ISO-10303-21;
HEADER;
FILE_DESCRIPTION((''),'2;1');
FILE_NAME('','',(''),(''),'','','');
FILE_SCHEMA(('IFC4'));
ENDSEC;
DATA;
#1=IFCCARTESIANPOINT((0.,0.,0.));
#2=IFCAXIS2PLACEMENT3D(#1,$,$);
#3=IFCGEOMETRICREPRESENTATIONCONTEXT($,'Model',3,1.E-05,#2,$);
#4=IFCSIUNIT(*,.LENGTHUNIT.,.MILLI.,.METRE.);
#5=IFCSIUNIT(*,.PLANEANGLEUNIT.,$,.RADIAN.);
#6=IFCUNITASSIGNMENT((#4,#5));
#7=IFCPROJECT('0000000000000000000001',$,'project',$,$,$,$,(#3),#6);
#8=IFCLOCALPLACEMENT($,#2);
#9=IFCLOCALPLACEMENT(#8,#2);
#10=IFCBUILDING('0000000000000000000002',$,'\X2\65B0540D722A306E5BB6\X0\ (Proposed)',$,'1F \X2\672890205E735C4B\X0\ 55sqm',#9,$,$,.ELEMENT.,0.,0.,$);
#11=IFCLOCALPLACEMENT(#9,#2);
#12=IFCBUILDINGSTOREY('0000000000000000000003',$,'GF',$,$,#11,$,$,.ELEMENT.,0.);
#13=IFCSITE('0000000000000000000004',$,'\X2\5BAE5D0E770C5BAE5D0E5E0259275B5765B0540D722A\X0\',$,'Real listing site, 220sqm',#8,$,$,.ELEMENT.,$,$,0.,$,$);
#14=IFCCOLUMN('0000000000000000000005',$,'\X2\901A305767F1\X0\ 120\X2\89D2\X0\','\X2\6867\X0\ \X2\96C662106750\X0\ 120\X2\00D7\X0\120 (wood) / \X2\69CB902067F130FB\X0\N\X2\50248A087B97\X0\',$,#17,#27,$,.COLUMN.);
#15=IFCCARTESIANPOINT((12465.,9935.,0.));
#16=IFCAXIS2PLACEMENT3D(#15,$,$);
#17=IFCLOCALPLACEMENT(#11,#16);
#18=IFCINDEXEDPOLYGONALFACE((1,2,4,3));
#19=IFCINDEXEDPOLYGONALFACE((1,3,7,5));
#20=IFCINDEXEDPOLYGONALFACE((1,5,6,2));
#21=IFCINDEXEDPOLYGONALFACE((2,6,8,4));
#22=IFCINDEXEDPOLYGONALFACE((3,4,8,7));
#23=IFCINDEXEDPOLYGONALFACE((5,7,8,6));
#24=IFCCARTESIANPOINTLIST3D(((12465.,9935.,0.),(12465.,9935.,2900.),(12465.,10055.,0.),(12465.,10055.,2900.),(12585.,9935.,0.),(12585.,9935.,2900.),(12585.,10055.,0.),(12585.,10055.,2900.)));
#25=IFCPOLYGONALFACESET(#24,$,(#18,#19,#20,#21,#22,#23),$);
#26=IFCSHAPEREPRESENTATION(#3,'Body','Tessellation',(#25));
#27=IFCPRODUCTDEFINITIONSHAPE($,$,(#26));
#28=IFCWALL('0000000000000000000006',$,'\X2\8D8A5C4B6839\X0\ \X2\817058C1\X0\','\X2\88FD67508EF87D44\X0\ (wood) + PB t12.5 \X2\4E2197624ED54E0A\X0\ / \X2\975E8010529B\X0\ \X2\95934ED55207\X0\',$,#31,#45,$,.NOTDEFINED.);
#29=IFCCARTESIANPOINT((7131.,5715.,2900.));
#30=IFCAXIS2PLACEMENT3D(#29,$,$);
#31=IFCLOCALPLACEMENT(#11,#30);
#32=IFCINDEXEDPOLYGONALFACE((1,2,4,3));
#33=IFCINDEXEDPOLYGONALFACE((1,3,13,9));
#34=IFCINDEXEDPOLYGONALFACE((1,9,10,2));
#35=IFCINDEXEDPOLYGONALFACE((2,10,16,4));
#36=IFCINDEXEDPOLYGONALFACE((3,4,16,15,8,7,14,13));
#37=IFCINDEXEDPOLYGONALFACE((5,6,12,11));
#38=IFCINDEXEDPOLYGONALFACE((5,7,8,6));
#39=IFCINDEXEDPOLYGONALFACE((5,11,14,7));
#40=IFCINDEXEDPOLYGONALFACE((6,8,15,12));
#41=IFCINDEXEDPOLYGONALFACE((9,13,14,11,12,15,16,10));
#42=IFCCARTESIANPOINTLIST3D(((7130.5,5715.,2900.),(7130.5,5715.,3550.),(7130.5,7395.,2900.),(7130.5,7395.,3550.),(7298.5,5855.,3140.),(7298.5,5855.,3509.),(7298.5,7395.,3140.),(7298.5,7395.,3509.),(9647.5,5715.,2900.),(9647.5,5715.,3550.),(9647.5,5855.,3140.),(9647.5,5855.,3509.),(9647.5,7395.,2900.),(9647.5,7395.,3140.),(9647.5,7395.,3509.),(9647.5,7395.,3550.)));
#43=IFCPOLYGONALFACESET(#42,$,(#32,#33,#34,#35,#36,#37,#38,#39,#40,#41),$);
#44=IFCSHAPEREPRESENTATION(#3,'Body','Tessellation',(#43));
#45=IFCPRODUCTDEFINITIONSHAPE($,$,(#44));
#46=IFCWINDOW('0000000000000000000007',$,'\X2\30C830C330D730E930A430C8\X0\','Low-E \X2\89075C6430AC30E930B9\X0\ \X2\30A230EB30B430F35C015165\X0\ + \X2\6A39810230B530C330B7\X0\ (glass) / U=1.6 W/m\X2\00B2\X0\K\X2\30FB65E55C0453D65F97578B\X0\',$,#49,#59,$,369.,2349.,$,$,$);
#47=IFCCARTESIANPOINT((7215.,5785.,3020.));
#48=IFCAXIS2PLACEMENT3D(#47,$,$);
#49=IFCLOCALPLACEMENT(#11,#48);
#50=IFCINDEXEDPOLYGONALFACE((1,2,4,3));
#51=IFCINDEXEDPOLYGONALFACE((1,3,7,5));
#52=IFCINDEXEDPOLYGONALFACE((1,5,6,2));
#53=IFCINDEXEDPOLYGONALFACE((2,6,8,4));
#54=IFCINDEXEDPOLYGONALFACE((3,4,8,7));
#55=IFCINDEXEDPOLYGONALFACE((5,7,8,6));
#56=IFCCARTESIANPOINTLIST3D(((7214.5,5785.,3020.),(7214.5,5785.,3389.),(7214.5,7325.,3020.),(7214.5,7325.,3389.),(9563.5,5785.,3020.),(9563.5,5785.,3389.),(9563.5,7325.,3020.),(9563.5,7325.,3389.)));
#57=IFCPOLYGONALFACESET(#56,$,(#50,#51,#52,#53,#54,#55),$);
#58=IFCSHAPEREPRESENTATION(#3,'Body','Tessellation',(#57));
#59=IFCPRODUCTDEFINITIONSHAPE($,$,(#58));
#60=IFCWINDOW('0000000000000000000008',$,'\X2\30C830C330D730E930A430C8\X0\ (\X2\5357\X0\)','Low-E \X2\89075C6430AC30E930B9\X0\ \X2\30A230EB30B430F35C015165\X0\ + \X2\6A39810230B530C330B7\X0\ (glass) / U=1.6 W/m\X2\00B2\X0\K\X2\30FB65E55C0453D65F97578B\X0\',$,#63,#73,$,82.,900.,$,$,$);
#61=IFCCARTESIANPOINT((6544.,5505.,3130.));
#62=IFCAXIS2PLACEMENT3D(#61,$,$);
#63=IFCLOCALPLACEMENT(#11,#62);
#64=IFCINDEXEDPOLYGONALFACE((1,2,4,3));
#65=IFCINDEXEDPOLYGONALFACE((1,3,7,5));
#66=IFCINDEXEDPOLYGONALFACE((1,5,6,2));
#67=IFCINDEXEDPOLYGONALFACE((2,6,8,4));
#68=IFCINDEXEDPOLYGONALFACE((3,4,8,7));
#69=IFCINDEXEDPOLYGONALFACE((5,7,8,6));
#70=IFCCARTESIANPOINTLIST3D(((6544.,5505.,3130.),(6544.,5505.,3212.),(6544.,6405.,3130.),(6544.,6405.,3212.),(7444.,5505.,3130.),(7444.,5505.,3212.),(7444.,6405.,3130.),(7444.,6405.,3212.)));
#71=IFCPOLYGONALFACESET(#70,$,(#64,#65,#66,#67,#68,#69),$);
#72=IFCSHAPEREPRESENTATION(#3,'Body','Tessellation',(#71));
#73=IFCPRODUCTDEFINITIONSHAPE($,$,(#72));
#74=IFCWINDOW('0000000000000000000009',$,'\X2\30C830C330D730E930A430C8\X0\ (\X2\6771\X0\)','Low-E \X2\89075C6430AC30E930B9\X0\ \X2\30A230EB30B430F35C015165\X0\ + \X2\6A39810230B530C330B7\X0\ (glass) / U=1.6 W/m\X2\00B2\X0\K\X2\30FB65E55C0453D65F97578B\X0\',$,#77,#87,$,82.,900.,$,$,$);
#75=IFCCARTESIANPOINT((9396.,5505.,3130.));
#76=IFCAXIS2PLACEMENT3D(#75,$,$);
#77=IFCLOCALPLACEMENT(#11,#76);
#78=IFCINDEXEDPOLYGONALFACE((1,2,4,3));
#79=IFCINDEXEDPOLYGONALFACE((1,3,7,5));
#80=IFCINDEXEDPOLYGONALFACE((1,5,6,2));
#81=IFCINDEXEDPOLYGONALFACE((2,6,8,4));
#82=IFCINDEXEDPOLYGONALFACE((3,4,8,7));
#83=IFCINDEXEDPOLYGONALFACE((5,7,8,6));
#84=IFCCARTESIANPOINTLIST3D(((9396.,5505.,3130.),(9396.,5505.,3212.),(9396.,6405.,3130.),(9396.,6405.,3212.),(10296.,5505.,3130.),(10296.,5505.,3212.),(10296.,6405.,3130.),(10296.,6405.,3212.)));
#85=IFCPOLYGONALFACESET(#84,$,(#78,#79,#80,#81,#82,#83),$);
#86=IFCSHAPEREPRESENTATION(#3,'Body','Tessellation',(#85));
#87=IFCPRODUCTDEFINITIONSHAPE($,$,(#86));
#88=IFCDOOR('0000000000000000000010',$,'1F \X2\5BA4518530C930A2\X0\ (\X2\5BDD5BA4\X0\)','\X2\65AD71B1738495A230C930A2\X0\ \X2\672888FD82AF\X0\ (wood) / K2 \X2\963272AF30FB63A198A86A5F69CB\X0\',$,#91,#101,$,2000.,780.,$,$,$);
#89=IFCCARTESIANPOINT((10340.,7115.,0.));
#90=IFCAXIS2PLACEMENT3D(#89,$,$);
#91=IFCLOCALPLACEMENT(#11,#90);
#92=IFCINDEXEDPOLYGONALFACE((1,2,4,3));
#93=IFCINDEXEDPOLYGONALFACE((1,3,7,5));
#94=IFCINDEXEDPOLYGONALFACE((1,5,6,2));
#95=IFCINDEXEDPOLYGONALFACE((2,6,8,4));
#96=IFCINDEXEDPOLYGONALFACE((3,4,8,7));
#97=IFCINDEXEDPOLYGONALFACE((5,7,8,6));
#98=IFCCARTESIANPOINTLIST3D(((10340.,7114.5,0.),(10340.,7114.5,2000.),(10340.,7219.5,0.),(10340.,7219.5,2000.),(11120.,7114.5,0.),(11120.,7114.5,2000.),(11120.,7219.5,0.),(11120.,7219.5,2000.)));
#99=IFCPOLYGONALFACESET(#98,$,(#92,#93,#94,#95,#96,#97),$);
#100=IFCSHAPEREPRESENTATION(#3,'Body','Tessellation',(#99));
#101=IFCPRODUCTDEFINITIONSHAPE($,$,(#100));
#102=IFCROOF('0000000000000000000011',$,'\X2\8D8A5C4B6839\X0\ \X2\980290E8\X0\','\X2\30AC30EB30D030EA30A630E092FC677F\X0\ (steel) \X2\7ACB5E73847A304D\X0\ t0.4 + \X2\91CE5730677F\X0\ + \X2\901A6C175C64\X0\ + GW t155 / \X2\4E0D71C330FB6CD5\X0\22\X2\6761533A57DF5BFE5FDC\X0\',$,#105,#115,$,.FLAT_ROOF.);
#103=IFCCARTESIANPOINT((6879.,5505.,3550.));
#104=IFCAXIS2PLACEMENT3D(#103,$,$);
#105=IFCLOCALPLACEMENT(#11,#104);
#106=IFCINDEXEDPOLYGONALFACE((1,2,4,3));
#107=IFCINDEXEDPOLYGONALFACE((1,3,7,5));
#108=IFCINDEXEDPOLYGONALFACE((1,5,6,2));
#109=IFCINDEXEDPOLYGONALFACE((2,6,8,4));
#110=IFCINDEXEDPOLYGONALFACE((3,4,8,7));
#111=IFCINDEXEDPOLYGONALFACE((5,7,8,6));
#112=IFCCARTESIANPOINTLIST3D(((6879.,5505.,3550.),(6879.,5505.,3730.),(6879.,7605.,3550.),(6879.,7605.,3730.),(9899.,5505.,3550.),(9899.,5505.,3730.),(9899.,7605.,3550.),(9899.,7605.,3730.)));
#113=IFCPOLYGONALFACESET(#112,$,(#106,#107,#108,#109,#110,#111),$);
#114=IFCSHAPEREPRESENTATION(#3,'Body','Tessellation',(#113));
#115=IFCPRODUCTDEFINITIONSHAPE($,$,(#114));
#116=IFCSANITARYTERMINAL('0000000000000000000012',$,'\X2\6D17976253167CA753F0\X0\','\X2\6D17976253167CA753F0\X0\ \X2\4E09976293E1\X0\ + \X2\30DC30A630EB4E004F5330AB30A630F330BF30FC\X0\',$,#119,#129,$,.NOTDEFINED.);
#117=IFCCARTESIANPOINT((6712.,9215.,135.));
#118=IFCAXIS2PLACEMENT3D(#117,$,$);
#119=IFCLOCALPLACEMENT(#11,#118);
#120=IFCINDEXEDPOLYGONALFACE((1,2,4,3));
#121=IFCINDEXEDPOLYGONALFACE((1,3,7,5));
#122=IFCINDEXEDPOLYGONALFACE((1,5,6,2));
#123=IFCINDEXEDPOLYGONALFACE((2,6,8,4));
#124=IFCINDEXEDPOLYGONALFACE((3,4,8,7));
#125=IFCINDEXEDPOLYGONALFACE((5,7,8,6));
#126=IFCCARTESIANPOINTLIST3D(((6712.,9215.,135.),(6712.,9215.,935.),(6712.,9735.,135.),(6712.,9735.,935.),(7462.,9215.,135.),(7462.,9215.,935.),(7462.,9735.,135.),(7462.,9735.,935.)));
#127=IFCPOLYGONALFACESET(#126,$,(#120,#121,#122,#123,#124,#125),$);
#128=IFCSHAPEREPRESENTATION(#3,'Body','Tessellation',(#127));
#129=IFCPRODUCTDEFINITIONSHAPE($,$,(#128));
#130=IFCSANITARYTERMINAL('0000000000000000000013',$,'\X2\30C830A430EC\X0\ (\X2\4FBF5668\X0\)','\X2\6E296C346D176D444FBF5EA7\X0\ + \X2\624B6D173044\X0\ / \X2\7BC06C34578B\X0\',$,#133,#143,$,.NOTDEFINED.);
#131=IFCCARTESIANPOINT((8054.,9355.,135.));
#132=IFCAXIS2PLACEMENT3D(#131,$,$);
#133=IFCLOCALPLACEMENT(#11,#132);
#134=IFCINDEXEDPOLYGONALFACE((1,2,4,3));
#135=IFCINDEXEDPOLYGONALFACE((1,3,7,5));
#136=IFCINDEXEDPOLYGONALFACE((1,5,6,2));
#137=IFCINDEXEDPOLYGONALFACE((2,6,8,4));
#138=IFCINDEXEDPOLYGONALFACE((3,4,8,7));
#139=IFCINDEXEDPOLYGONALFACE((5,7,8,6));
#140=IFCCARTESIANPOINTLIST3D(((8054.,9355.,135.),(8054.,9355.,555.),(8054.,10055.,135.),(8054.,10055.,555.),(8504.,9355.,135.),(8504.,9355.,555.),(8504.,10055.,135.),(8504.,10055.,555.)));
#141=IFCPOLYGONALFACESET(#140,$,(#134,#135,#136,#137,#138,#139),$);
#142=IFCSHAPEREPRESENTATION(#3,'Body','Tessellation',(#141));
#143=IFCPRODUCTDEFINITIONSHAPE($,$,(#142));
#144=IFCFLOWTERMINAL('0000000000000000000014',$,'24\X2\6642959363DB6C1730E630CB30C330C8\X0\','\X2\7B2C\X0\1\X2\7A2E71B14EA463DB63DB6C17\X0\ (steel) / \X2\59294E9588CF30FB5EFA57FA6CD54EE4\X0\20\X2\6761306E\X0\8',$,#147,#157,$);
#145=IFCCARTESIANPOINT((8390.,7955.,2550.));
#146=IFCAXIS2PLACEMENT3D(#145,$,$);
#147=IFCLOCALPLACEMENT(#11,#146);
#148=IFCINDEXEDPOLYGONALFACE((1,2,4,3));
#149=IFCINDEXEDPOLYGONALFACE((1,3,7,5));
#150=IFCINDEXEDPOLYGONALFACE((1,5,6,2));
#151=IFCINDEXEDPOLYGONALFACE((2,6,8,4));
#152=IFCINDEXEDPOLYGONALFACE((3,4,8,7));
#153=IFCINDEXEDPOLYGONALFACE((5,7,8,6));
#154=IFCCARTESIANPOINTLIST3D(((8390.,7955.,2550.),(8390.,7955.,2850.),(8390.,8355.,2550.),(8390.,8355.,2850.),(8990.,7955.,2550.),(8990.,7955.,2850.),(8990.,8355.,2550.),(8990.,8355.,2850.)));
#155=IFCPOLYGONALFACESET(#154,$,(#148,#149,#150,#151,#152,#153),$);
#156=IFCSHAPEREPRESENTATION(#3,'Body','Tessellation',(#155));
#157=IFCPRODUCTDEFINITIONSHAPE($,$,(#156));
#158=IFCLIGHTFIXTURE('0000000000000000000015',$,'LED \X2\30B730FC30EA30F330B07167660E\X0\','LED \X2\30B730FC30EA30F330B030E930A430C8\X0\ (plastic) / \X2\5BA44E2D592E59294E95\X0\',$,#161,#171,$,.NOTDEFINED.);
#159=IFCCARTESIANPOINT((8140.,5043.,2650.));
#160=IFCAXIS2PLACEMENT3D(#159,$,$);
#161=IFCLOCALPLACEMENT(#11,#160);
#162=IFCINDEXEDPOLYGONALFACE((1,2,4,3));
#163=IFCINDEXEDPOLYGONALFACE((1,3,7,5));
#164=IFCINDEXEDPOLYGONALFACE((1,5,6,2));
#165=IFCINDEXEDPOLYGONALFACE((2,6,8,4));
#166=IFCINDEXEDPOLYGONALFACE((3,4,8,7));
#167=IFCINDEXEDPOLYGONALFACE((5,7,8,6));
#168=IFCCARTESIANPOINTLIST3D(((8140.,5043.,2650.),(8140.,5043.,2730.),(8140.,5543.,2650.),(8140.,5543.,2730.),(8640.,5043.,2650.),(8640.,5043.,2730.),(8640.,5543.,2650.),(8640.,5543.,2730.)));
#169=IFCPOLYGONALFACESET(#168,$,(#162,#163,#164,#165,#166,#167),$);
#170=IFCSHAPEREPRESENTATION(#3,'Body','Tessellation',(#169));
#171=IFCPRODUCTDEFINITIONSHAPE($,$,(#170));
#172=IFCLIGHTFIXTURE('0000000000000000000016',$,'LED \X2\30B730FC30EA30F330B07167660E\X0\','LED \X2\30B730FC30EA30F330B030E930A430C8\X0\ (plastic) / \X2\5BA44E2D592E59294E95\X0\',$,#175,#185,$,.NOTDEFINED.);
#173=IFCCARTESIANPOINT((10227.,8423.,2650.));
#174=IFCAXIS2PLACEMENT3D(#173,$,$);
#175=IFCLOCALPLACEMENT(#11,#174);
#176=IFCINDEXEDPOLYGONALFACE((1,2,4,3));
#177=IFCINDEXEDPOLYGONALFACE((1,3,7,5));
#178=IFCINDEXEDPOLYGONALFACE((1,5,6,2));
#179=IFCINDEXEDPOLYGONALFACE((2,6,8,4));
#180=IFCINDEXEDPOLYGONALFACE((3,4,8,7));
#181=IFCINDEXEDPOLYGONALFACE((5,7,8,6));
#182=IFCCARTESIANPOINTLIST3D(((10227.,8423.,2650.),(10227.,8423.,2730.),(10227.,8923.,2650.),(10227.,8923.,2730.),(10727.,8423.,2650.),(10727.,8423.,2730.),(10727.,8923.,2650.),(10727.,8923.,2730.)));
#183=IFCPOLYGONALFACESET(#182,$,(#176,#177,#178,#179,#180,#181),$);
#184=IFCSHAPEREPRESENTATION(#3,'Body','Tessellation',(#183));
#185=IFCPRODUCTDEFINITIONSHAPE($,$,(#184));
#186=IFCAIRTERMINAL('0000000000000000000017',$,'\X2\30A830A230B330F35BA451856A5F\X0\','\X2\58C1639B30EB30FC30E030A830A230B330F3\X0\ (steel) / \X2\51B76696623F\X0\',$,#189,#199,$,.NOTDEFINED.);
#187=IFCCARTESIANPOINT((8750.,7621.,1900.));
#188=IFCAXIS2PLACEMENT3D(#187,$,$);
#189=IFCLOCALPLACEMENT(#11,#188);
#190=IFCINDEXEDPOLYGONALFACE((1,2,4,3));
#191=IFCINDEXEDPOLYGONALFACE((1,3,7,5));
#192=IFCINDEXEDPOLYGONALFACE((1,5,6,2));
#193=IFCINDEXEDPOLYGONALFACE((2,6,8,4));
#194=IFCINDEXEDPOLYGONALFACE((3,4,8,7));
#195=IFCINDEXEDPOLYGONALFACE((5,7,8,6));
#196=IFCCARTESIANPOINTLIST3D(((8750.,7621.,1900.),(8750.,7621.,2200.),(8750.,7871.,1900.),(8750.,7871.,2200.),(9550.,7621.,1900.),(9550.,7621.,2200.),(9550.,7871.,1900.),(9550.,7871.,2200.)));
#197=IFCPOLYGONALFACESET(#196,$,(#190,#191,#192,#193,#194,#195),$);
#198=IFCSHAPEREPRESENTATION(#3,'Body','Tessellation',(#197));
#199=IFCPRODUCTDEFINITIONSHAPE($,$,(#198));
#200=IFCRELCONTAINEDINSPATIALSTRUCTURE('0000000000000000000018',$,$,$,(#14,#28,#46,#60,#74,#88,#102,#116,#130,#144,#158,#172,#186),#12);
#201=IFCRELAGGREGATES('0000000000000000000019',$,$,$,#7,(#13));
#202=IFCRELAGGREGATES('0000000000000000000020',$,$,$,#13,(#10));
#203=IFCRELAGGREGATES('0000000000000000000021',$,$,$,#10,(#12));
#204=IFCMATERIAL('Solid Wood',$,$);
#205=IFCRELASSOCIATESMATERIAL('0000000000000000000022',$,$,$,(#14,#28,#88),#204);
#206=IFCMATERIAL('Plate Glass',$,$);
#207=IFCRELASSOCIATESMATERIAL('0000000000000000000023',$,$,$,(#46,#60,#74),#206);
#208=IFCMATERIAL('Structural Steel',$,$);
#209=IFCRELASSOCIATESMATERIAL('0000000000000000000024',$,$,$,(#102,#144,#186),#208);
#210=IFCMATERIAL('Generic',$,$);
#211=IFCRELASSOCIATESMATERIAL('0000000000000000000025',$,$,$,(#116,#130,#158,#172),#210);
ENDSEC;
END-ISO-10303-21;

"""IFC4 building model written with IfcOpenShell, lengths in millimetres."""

from ifc_helpers import new_model, si_unit, frame, frame_2d, origin, place, context, project, spatial, rectangle, extrude, material, element, fill, save


model = new_model("IFC4")

# Units and contexts
model_context = context("Model", 3, precision=1e-05, world=origin())
ifc_project = project(units=[si_unit("LENGTHUNIT", "METRE", prefix="MILLI"), si_unit("PLANEANGLEUNIT", "RADIAN")], contexts=[model_context])

# Site, building, storey
site_placement = place(None, origin())
site = spatial("IfcSite", under=ifc_project, at=site_placement, Name="宮崎県宮崎市大字新名爪", ObjectType="Real listing site, 220sqm", CompositionType="ELEMENT", RefElevation=0.0)
building_placement = place(site_placement, origin())
building = spatial("IfcBuilding", under=site, at=building_placement, Name="新名爪の家 (Proposed)", ObjectType="1F 木造平屋 55sqm", CompositionType="ELEMENT", ElevationOfRefHeight=0.0, ElevationOfTerrain=0.0)
storey_placement = place(building_placement, origin())
storey = spatial("IfcBuildingStorey", under=building, at=storey_placement, Name="GF", CompositionType="ELEMENT", Elevation=0.0)

# Column
ifc_material_1 = material(Name="Solid Wood")
column_1_placement = place(storey_placement, frame((12465.0, 9935.0, 0.0)))
element("IfcColumn", 1, at=column_1_placement, inside=storey, material=ifc_material_1, Name="通し柱 120角", Description="桧 集成材 120×120 (wood) / 構造柱・N値計算", PredefinedType="COLUMN", context=model_context, shape_type="SweptSolid", body=[
    extrude(rectangle(XDim=120.0, YDim=120.0, at=frame_2d((60.0, 60.0))), frame((12465.0, 9935.0, 0.0)), (0.0, 0.0, 1.0), 2900.0),
])

# Wall, openings, windows
wall_1_placement = place(storey_placement, frame((7131.0, 5715.0, 2900.0)))
wall_1 = element("IfcWall", 2, at=wall_1_placement, inside=storey, material=ifc_material_1, Name="越屋根 腰壁", Description="製材軸組 (wood) + PB t12.5 両面仕上 / 非耐力 間仕切", PredefinedType="NOTDEFINED", context=model_context, shape_type="SweptSolid", body=[
    extrude(rectangle(XDim=2517.0, YDim=1680.0, at=frame_2d((1258.0, 840.0))), frame((7131.0, 5715.0, 2900.0)), (0.0, 0.0, 1.0), 650.0),
])
opening_1_placement = place(storey_placement, frame((7215.0, 5785.0, 3020.0)))
opening_1 = element("IfcOpeningElement", 3, at=opening_1_placement, cuts=wall_1, PredefinedType="NOTDEFINED", context=model_context, shape_type="SweptSolid", body=[
    extrude(rectangle(XDim=2349.0, YDim=1540.0, at=frame_2d((1174.0, 770.0))), frame((7215.0, 5785.0, 3020.0)), (0.0, 0.0, 1.0), 369.0),
])
opening_2_placement = place(storey_placement, frame((6544.0, 5505.0, 3130.0)))
opening_2 = element("IfcOpeningElement", 4, at=opening_2_placement, cuts=wall_1, PredefinedType="NOTDEFINED", context=model_context, shape_type="SweptSolid", body=[
    extrude(rectangle(XDim=900.0, YDim=900.0, at=frame_2d((450.0, 450.0))), frame((6544.0, 5505.0, 3130.0)), (0.0, 0.0, 1.0), 82.0),
])
opening_3_placement = place(storey_placement, frame((9396.0, 5505.0, 3130.0)))
opening_3 = element("IfcOpeningElement", 5, at=opening_3_placement, cuts=wall_1, PredefinedType="NOTDEFINED", context=model_context, shape_type="SweptSolid", body=[
    extrude(rectangle(XDim=900.0, YDim=900.0, at=frame_2d((450.0, 450.0))), frame((9396.0, 5505.0, 3130.0)), (0.0, 0.0, 1.0), 82.0),
])
ifc_material_2 = material(Name="Plate Glass")
window_1_placement = place(storey_placement, frame((7215.0, 5785.0, 3020.0)))
window_1 = element("IfcWindow", 6, at=window_1_placement, inside=storey, material=ifc_material_2, Name="トップライト", Description="Low-E 複層ガラス アルゴン封入 + 樹脂サッシ (glass) / U=1.6 W/m²K・日射取得型", OverallHeight=369.0, OverallWidth=2349.0, context=model_context, shape_type="SweptSolid", body=[
    extrude(rectangle(XDim=2349.0, YDim=1540.0, at=frame_2d((1174.0, 770.0))), frame((7215.0, 5785.0, 3020.0)), (0.0, 0.0, 1.0), 369.0),
])
fill(opening_1, window_1)
window_2_placement = place(storey_placement, frame((6544.0, 5505.0, 3130.0)))
window_2 = element("IfcWindow", 7, at=window_2_placement, inside=storey, material=ifc_material_2, Name="トップライト (南)", Description="Low-E 複層ガラス アルゴン封入 + 樹脂サッシ (glass) / U=1.6 W/m²K・日射取得型", OverallHeight=82.0, OverallWidth=900.0, context=model_context, shape_type="SweptSolid", body=[
    extrude(rectangle(XDim=900.0, YDim=900.0, at=frame_2d((450.0, 450.0))), frame((6544.0, 5505.0, 3130.0)), (0.0, 0.0, 1.0), 82.0),
])
fill(opening_2, window_2)
window_3_placement = place(storey_placement, frame((9396.0, 5505.0, 3130.0)))
window_3 = element("IfcWindow", 8, at=window_3_placement, inside=storey, material=ifc_material_2, Name="トップライト (東)", Description="Low-E 複層ガラス アルゴン封入 + 樹脂サッシ (glass) / U=1.6 W/m²K・日射取得型", OverallHeight=82.0, OverallWidth=900.0, context=model_context, shape_type="SweptSolid", body=[
    extrude(rectangle(XDim=900.0, YDim=900.0, at=frame_2d((450.0, 450.0))), frame((9396.0, 5505.0, 3130.0)), (0.0, 0.0, 1.0), 82.0),
])
fill(opening_3, window_3)

# Door
door_placement = place(storey_placement, frame((10340.0, 7115.0, 0.0)))
element("IfcDoor", 9, at=door_placement, inside=storey, material=ifc_material_1, Name="1F 室内ドア (寝室)", Description="断熱玄関ドア 木製芯 (wood) / K2 防犯・採風機構", OverallHeight=2000.0, OverallWidth=780.0, context=model_context, shape_type="SweptSolid", body=[
    extrude(rectangle(XDim=780.0, YDim=105.0, at=frame_2d((390.0, 52.0))), frame((10340.0, 7115.0, 0.0)), (0.0, 0.0, 1.0), 2000.0),
])

# Roof
ifc_material_3 = material(Name="Structural Steel")
roof_placement = place(storey_placement, frame((6879.0, 5505.0, 3550.0)))
element("IfcRoof", 10, at=roof_placement, inside=storey, material=ifc_material_3, Name="越屋根 頂部", Description="ガルバリウム鋼板 (steel) 立平葺き t0.4 + 野地板 + 通気層 + GW t155 / 不燃・法22条区域対応", PredefinedType="FLAT_ROOF", context=model_context, shape_type="SweptSolid", body=[
    extrude(rectangle(XDim=3020.0, YDim=2100.0, at=frame_2d((1510.0, 1050.0))), frame((6879.0, 5505.0, 3550.0)), (0.0, 0.0, 1.0), 180.0),
])

# Sanitary terminals
ifc_material_4 = material(Name="Generic")
sanitary_terminal_1_placement = place(storey_placement, frame((6712.0, 9215.0, 135.0)))
element("IfcSanitaryTerminal", 11, at=sanitary_terminal_1_placement, inside=storey, material=ifc_material_4, Name="洗面化粧台", Description="洗面化粧台 三面鏡 + ボウル一体カウンター", PredefinedType="NOTDEFINED", context=model_context, shape_type="SweptSolid", body=[
    extrude(rectangle(XDim=750.0, YDim=520.0, at=frame_2d((375.0, 260.0))), frame((6712.0, 9215.0, 135.0)), (0.0, 0.0, 1.0), 800.0),
])
sanitary_terminal_2_placement = place(storey_placement, frame((8054.0, 9355.0, 135.0)))
element("IfcSanitaryTerminal", 12, at=sanitary_terminal_2_placement, inside=storey, material=ifc_material_4, Name="トイレ (便器)", Description="温水洗浄便座 + 手洗い / 節水型", PredefinedType="NOTDEFINED", context=model_context, shape_type="SweptSolid", body=[
    extrude(rectangle(XDim=450.0, YDim=700.0, at=frame_2d((225.0, 350.0))), frame((8054.0, 9355.0, 135.0)), (0.0, 0.0, 1.0), 420.0),
])

# Flow terminal
flow_terminal_placement = place(storey_placement, frame((8390.0, 7955.0, 2550.0)))
element("IfcFlowTerminal", 13, at=flow_terminal_placement, inside=storey, material=ifc_material_3, Name="24時間換気ユニット", Description="第1種熱交換換気 (steel) / 天井裏・建基法令20条の8", context=model_context, shape_type="SweptSolid", body=[
    extrude(rectangle(XDim=600.0, YDim=400.0, at=frame_2d((300.0, 200.0))), frame((8390.0, 7955.0, 2550.0)), (0.0, 0.0, 1.0), 300.0),
])

# Light fixtures
light_fixture_1_placement = place(storey_placement, frame((8140.0, 5043.0, 2650.0)))
element("IfcLightFixture", 14, at=light_fixture_1_placement, inside=storey, material=ifc_material_4, Name="LED シーリング照明", Description="LED シーリングライト (plastic) / 室中央天井", PredefinedType="NOTDEFINED", context=model_context, shape_type="SweptSolid", body=[
    extrude(rectangle(XDim=500.0, YDim=500.0, at=frame_2d((250.0, 250.0))), frame((8140.0, 5043.0, 2650.0)), (0.0, 0.0, 1.0), 80.0),
])
light_fixture_2_placement = place(storey_placement, frame((10227.0, 8423.0, 2650.0)))
element("IfcLightFixture", 15, at=light_fixture_2_placement, inside=storey, material=ifc_material_4, Name="LED シーリング照明", Description="LED シーリングライト (plastic) / 室中央天井", PredefinedType="NOTDEFINED", context=model_context, shape_type="SweptSolid", body=[
    extrude(rectangle(XDim=500.0, YDim=500.0, at=frame_2d((250.0, 250.0))), frame((10227.0, 8423.0, 2650.0)), (0.0, 0.0, 1.0), 80.0),
])

# Air terminal
air_terminal_placement = place(storey_placement, frame((8750.0, 7621.0, 1900.0)))
element("IfcAirTerminal", 16, at=air_terminal_placement, inside=storey, material=ifc_material_3, Name="エアコン室内機", Description="壁掛ルームエアコン (steel) / 冷暖房", PredefinedType="NOTDEFINED", context=model_context, shape_type="SweptSolid", body=[
    extrude(rectangle(XDim=800.0, YDim=250.0, at=frame_2d((400.0, 125.0))), frame((8750.0, 7621.0, 1900.0)), (0.0, 0.0, 1.0), 300.0),
])

save(model, "model.ifc")
